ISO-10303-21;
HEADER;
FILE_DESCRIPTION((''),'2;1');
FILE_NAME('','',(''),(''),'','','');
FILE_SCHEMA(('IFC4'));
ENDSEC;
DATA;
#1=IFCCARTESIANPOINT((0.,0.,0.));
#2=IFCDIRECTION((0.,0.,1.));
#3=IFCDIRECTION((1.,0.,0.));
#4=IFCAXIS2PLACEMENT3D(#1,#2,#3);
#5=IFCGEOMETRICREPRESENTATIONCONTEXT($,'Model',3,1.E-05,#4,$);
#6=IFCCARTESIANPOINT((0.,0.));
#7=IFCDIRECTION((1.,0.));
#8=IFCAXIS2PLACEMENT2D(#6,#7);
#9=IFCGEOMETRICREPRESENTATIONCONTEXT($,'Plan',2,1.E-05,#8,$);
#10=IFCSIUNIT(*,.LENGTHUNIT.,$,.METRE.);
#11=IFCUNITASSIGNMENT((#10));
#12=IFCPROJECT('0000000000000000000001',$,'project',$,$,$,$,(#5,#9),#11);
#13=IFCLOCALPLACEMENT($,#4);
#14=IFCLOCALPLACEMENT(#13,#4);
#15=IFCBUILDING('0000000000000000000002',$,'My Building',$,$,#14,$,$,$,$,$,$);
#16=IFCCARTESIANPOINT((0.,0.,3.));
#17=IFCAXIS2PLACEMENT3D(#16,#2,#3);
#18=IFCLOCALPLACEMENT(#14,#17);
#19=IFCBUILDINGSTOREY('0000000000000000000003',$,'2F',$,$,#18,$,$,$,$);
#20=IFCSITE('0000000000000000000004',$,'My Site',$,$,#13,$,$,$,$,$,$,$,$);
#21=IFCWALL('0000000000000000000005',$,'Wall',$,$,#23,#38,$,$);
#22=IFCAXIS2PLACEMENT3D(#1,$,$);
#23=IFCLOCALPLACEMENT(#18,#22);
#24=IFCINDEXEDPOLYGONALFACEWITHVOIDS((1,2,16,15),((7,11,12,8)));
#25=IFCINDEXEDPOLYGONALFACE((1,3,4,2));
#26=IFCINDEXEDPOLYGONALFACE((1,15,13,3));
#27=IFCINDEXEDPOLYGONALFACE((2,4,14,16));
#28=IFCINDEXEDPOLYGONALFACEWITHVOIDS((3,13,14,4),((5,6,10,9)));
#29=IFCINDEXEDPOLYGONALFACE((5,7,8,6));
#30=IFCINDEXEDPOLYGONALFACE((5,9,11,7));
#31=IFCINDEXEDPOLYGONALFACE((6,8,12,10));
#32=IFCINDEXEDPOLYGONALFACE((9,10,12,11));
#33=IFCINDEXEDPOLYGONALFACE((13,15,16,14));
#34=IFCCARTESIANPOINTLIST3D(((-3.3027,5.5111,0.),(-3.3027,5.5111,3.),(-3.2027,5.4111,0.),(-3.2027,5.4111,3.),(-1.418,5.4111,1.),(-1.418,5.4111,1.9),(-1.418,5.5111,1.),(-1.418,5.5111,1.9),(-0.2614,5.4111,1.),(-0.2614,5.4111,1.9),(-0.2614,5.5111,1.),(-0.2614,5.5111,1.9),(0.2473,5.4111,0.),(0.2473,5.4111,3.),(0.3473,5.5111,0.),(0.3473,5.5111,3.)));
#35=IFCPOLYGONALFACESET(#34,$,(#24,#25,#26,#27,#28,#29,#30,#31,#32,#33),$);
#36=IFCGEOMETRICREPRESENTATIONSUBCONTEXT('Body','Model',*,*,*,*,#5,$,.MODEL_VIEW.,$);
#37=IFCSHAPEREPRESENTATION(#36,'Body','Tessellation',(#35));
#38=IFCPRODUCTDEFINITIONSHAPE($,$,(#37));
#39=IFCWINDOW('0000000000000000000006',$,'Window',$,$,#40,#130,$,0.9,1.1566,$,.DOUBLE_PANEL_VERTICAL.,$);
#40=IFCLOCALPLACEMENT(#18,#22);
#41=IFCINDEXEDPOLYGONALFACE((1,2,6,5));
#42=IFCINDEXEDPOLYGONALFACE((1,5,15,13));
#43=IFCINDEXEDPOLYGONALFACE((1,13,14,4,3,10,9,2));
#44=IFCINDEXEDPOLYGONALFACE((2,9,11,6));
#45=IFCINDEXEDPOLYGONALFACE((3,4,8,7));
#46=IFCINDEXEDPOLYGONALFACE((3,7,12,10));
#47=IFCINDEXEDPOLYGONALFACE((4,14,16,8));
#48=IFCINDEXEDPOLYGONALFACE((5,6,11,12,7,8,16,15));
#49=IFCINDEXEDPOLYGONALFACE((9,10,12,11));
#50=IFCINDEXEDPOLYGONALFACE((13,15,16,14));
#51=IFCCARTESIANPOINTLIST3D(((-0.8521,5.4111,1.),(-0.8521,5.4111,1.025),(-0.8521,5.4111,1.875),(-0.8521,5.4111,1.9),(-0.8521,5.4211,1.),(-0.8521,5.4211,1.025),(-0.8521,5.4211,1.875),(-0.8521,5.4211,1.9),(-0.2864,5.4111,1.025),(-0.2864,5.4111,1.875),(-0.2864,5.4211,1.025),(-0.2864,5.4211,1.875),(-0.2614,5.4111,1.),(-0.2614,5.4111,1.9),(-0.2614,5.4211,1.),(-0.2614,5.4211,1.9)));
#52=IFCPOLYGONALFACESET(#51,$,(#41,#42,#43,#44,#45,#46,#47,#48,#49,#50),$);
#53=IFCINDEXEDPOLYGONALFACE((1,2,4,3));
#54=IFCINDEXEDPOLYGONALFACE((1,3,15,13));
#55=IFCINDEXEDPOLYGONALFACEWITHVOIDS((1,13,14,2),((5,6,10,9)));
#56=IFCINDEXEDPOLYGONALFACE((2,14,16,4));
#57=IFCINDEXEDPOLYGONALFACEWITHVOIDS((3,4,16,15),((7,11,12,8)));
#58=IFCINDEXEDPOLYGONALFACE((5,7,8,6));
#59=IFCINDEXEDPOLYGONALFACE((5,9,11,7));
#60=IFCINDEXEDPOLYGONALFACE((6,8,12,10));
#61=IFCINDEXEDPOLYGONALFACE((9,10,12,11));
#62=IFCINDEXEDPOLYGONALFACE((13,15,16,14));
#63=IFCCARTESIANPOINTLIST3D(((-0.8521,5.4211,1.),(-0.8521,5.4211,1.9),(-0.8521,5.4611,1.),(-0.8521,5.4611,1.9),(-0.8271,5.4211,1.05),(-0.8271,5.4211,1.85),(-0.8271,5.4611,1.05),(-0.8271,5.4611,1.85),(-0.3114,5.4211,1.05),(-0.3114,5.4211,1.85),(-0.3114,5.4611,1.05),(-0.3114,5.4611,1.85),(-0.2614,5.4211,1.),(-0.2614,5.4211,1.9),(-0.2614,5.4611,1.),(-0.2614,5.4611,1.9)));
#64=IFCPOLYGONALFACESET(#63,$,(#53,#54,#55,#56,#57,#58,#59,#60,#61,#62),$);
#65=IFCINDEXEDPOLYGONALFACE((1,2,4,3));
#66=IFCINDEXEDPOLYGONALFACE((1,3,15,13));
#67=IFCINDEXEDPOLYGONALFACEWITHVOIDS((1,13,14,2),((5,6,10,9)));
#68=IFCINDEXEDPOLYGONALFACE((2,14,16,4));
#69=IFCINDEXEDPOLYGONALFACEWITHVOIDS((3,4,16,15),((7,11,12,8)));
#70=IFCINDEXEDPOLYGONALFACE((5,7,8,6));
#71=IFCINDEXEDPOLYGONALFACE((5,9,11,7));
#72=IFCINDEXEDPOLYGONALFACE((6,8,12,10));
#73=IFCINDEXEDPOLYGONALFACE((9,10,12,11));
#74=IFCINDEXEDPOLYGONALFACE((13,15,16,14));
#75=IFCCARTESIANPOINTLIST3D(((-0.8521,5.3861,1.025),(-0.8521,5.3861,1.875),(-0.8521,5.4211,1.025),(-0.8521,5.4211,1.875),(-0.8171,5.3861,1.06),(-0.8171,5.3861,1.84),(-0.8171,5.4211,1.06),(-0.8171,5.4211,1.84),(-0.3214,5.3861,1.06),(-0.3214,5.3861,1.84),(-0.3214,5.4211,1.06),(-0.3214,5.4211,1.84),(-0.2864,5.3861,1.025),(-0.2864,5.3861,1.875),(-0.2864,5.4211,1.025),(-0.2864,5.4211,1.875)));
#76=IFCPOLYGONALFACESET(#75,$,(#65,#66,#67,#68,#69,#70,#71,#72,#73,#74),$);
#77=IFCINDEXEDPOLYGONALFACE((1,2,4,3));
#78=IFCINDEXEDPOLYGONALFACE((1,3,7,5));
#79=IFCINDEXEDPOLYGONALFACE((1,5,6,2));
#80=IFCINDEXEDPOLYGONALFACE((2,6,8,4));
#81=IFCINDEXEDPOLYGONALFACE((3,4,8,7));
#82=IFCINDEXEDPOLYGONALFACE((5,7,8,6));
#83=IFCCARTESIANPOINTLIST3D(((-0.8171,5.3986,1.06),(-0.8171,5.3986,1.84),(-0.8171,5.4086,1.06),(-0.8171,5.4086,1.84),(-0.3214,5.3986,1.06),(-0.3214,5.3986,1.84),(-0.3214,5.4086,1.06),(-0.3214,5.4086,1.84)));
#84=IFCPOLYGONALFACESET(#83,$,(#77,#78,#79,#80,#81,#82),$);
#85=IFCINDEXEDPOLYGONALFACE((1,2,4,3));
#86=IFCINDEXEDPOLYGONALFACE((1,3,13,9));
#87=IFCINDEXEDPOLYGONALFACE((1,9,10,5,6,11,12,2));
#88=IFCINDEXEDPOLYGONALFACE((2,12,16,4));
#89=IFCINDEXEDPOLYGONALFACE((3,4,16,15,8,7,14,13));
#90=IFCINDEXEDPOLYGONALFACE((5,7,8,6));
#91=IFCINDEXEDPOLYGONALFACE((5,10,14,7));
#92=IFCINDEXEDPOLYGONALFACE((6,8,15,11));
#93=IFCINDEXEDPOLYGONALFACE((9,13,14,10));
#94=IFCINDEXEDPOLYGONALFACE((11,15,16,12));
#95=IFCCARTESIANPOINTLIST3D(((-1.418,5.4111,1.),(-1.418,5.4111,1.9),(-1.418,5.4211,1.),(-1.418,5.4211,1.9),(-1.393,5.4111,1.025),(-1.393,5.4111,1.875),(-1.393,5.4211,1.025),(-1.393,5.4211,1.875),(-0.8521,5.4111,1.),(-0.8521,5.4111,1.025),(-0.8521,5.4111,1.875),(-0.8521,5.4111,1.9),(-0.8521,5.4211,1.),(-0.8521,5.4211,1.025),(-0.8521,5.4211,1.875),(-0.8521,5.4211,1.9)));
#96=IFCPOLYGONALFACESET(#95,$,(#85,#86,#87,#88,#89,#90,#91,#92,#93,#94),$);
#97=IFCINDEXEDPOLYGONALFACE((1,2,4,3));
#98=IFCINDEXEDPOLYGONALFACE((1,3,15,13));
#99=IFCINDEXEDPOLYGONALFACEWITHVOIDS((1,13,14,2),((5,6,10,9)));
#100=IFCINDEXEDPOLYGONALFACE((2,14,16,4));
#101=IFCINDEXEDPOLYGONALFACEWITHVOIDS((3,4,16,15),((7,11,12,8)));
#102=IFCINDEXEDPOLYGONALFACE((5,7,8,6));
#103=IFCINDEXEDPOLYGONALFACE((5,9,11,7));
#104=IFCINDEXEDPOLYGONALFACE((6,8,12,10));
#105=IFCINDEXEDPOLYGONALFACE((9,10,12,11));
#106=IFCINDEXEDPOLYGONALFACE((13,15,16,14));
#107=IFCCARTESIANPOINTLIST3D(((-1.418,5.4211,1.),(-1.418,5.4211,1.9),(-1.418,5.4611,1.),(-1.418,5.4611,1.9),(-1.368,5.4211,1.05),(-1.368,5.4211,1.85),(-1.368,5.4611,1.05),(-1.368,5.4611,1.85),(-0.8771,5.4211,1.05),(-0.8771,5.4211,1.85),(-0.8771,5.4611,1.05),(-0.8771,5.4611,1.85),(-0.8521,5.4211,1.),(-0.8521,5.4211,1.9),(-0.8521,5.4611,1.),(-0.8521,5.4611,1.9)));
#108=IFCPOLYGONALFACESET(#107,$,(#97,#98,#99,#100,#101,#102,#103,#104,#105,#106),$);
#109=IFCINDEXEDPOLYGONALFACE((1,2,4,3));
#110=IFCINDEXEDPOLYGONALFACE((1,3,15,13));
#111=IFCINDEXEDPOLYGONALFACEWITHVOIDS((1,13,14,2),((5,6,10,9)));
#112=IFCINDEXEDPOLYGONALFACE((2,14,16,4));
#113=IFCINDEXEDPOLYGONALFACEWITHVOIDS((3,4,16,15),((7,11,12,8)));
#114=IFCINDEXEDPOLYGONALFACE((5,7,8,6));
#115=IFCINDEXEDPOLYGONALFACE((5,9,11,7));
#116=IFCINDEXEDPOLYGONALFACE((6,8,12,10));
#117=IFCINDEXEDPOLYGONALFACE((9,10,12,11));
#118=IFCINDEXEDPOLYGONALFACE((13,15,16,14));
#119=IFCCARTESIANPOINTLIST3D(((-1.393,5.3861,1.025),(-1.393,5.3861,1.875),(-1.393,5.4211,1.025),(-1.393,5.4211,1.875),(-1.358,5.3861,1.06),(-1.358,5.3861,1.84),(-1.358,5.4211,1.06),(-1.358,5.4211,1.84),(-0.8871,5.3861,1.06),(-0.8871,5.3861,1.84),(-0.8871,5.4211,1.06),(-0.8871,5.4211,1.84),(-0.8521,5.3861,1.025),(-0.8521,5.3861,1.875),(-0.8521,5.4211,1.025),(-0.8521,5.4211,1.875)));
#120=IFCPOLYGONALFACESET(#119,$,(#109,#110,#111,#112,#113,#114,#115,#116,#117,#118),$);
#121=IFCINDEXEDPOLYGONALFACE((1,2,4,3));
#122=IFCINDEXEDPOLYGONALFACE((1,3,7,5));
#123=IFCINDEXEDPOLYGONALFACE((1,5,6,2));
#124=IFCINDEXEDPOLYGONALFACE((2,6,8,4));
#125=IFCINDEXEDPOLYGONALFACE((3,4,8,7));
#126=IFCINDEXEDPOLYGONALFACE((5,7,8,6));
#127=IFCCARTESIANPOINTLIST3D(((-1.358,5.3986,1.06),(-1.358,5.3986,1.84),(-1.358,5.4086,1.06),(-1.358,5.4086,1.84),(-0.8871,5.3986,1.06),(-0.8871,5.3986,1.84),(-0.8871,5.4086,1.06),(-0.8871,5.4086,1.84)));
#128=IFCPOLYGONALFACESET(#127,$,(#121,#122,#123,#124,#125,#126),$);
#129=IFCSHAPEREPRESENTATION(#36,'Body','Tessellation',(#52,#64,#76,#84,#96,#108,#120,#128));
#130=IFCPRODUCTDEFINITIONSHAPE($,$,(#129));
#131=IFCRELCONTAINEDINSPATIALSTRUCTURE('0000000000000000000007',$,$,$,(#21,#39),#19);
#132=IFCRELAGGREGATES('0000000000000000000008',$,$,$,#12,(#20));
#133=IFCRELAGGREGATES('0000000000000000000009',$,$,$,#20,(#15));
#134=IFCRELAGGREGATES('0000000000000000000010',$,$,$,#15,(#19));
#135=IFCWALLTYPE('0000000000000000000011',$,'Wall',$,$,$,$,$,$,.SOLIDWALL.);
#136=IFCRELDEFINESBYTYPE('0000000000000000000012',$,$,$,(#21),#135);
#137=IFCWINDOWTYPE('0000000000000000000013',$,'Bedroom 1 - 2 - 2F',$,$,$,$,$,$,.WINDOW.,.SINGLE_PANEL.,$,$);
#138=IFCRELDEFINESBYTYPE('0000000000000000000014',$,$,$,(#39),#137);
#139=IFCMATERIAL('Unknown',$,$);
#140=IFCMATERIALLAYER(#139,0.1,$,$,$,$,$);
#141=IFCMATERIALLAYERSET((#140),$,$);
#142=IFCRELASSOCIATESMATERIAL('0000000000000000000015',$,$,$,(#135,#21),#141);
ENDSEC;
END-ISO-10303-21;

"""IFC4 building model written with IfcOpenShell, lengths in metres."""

from ifc_helpers import new_model, entity, si_unit, frame, origin_with_axes, origin_2d_with_axis, place, context, subcontext, project, spatial, line, indexed_curve, outline, extrude, shape, source, transform, mapped, material, layer, layer_set, layer_usage, type_object, type_shapes, element, fill, save


model = new_model("IFC4")

# Units and contexts
model_context = context("Model", 3, precision=1e-05, world=origin_with_axes())
plan_context = context("Plan", 2, precision=1e-05, world=origin_2d_with_axis())
body_context_1 = subcontext(model_context, "Body", "Model", "MODEL_VIEW")
body_context_2 = subcontext(plan_context, "Body", "Plan", "PLAN_VIEW")
ifc_project = project(units=[si_unit("LENGTHUNIT", "METRE")], contexts=[model_context, plan_context])

# Site, building, storey
site_placement = place(None, origin_with_axes())
site = spatial("IfcSite", under=ifc_project, at=site_placement, Name="My Site")
building_placement = place(site_placement, origin_with_axes())
building = spatial("IfcBuilding", under=site, at=building_placement, Name="My Building")
storey_placement = place(building_placement, frame((0.0, 0.0, 3.0), z_axis=(0.0, 0.0, 1.0), x_axis=(1.0, 0.0, 0.0)))
storey = spatial("IfcBuildingStorey", under=building, at=storey_placement, Name="2F")

# Shared definitions
ifc_material_1 = material(Name="Unknown")
ifc_layer_1 = layer(ifc_material_1, 0.1)
ifc_layer_set_1 = layer_set([ifc_layer_1])
wall_type_1 = type_object("IfcWallType", Name="Wall", PredefinedType="SOLIDWALL", material=ifc_layer_set_1)

# Wall, opening, window
ifc_layer_usage_1 = layer_usage(ifc_layer_set_1, "AXIS2", "POSITIVE", 0.0)
wall_1_placement = place(storey_placement, frame((0.3473, 5.5111, 0.0), z_axis=(0.0, 0.0, 1.0), x_axis=(-1.0, 0.0, 0.0)))
wall_1 = element("IfcWall", 1, at=wall_1_placement, inside=storey, type_object=wall_type_1, material=ifc_layer_usage_1, Name="Wall", context=body_context_1, shape_type="SweptSolid", body=[
    extrude(outline(indexed_curve([(0.0, 0.0), (0.1, 0.1), (3.55, 0.1), (3.65, 0.0)], segments=[line(1, 2, 3, 4, 1)])), origin_with_axes(), (0.0, 0.0, 1.0), 3.0),
])
shared_shape_1 = source(origin_with_axes(), body_context_1, "Body", "SweptSolid", [
    extrude(outline(indexed_curve([(0.0, 0.0), (1.1566, 0.0), (1.1566, 0.9), (0.0, 0.9)], segments=[line(1, 2, 3, 4, 1)])), frame((0.0, -0.6, 0.0), z_axis=(0.0, -1.0, 0.0), x_axis=(1.0, 0.0, 0.0)), (0.0, 0.0, -1.0), 1.2),
])
opening_1_placement = place(wall_1_placement, frame((0.6086, 0.0, 1.0), z_axis=(0.0, 0.0, 1.0), x_axis=(1.0, 0.0, 0.0)))
opening_1 = element("IfcOpeningElement", 2, at=opening_1_placement, cuts=wall_1, PredefinedType="OPENING", context=body_context_1, shape_type="MappedRepresentation", body=[
    mapped(shared_shape_1, transform((0.0, 0.0, 0.0), x_axis=(1.0, 0.0, 0.0), y_axis=(0.0, 1.0, 0.0), z_axis=(0.0, 0.0, 1.0), scale=1.0)),
])
window_type_1 = type_object("IfcWindowType", Name="Bedroom 1 - 2 - 2F", PartitioningType="SINGLE_PANEL", PredefinedType="WINDOW")
shared_shape_2 = source(origin_with_axes(), body_context_1, "Body", "SweptSolid", [
    extrude(outline(indexed_curve([(0.5908, 0.0), (0.0, 0.0), (0.0, 0.9), (0.5908, 0.9), (0.5908, 0.875), (0.025, 0.875), (0.025, 0.025), (0.5908, 0.025)], segments=[line(1, 2, 3, 4, 5, 6, 7, 8, 1)])), frame((0.0, 0.09, 0.0), z_axis=(0.0, -1.0, 0.0), x_axis=(1.0, 0.0, 0.0)), (0.0, 0.0, -1.0), 0.01),
    extrude(outline(indexed_curve([(0.0, 0.0), (0.5908, 0.0), (0.5908, 0.9), (0.0, 0.9)], segments=[line(1, 2, 3, 4, 1)]), holes=[indexed_curve([(0.05, 0.05), (0.5658, 0.05), (0.5658, 0.85), (0.05, 0.85)], segments=[line(1, 2, 3, 4, 1)])]), frame((0.0, 0.05, 0.0), z_axis=(0.0, -1.0, 0.0), x_axis=(1.0, 0.0, 0.0)), (0.0, 0.0, -1.0), 0.04),
    extrude(outline(indexed_curve([(0.0, 0.0), (0.5658, 0.0), (0.5658, 0.85), (0.0, 0.85)], segments=[line(1, 2, 3, 4, 1)]), holes=[indexed_curve([(0.035, 0.035), (0.5308, 0.035), (0.5308, 0.815), (0.035, 0.815)], segments=[line(1, 2, 3, 4, 1)])]), frame((0.025, 0.09, 0.025), z_axis=(0.0, -1.0, 0.0), x_axis=(1.0, 0.0, 0.0)), (0.0, 0.0, -1.0), 0.035),
    extrude(outline(indexed_curve([(0.035, 0.035), (0.5308, 0.035), (0.5308, 0.815), (0.035, 0.815)], segments=[line(1, 2, 3, 4, 1)])), frame((0.025, 0.1025, 0.025), z_axis=(0.0, -1.0, 0.0), x_axis=(1.0, 0.0, 0.0)), (0.0, 0.0, -1.0), 0.01),
    extrude(outline(indexed_curve([(0.0, 0.9), (0.5659, 0.9), (0.5659, 0.0), (0.0, 0.0), (0.0, 0.025), (0.5409, 0.025), (0.5409, 0.875), (0.0, 0.875)], segments=[line(1, 2, 3, 4, 5, 6, 7, 8, 1)])), frame((0.5908, 0.09, 0.0), z_axis=(0.0, -1.0, 0.0), x_axis=(1.0, 0.0, 0.0)), (0.0, 0.0, -1.0), 0.01),
    extrude(outline(indexed_curve([(0.0, 0.0), (0.5659, 0.0), (0.5659, 0.9), (0.0, 0.9)], segments=[line(1, 2, 3, 4, 1)]), holes=[indexed_curve([(0.025, 0.05), (0.5159, 0.05), (0.5159, 0.85), (0.025, 0.85)], segments=[line(1, 2, 3, 4, 1)])]), frame((0.5908, 0.05, 0.0), z_axis=(0.0, -1.0, 0.0), x_axis=(1.0, 0.0, 0.0)), (0.0, 0.0, -1.0), 0.04),
    extrude(outline(indexed_curve([(0.0, 0.0), (0.5409, 0.0), (0.5409, 0.85), (0.0, 0.85)], segments=[line(1, 2, 3, 4, 1)]), holes=[indexed_curve([(0.035, 0.035), (0.5059, 0.035), (0.5059, 0.815), (0.035, 0.815)], segments=[line(1, 2, 3, 4, 1)])]), frame((0.5908, 0.09, 0.025), z_axis=(0.0, -1.0, 0.0), x_axis=(1.0, 0.0, 0.0)), (0.0, 0.0, -1.0), 0.035),
    extrude(outline(indexed_curve([(0.035, 0.035), (0.5059, 0.035), (0.5059, 0.815), (0.035, 0.815)], segments=[line(1, 2, 3, 4, 1)])), frame((0.5908, 0.1025, 0.025), z_axis=(0.0, -1.0, 0.0), x_axis=(1.0, 0.0, 0.0)), (0.0, 0.0, -1.0), 0.01),
])
shared_shape_3 = source(origin_with_axes(), body_context_2, "Body", "Curve2D", [
    entity("IfcIndexedPolyCurve", entity("IfcCartesianPointList2D", [[0.05, 0.05], [0.5658, 0.05]])),
    entity("IfcIndexedPolyCurve", entity("IfcCartesianPointList2D", [[0.0, 0.1], [0.025, 0.1], [0.025, 0.09], [0.05, 0.09], [0.05, 0.05], [0.0, 0.05]]), [entity("IfcLineIndex", [1, 2, 3, 4, 5, 6, 1])]),
    entity("IfcIndexedPolyCurve", entity("IfcCartesianPointList2D", [[0.5908, 0.1], [0.5908, 0.1], [0.5908, 0.09], [0.5658, 0.09], [0.5658, 0.05], [0.5908, 0.05]])),
    entity("IfcIndexedPolyCurve", entity("IfcCartesianPointList2D", [[0.025, 0.09], [0.06, 0.09], [0.06, 0.125], [0.025, 0.125]]), [entity("IfcLineIndex", [1, 2, 3, 4, 1])]),
    entity("IfcIndexedPolyCurve", entity("IfcCartesianPointList2D", [[0.5908, 0.09], [0.5558, 0.09], [0.5558, 0.125], [0.5908, 0.125]]), [entity("IfcLineIndex", [1, 2, 3, 4, 1])]),
    entity("IfcIndexedPolyCurve", entity("IfcCartesianPointList2D", [[0.06, 0.09], [0.5558, 0.09]])),
    entity("IfcIndexedPolyCurve", entity("IfcCartesianPointList2D", [[0.06, 0.125], [0.5558, 0.125]])),
    entity("IfcIndexedPolyCurve", entity("IfcCartesianPointList2D", [[0.06, 0.1075], [0.5558, 0.1075]])),
    entity("IfcIndexedPolyCurve", entity("IfcCartesianPointList2D", [[0.6158, 0.05], [1.1066, 0.05]])),
    entity("IfcIndexedPolyCurve", entity("IfcCartesianPointList2D", [[0.5908, 0.1], [0.5908, 0.1], [0.5908, 0.09], [0.6158, 0.09], [0.6158, 0.05], [0.5908, 0.05]])),
    entity("IfcIndexedPolyCurve", entity("IfcCartesianPointList2D", [[1.1566, 0.1], [1.1316, 0.1], [1.1316, 0.09], [1.1066, 0.09], [1.1066, 0.05], [1.1566, 0.05]]), [entity("IfcLineIndex", [1, 2, 3, 4, 5, 6, 1])]),
    entity("IfcIndexedPolyCurve", entity("IfcCartesianPointList2D", [[0.5908, 0.09], [0.6258, 0.09], [0.6258, 0.125], [0.5908, 0.125]]), [entity("IfcLineIndex", [1, 2, 3, 4, 1])]),
    entity("IfcIndexedPolyCurve", entity("IfcCartesianPointList2D", [[1.1316, 0.09], [1.0966, 0.09], [1.0966, 0.125], [1.1316, 0.125]]), [entity("IfcLineIndex", [1, 2, 3, 4, 1])]),
    entity("IfcIndexedPolyCurve", entity("IfcCartesianPointList2D", [[0.6258, 0.09], [1.0966, 0.09]])),
    entity("IfcIndexedPolyCurve", entity("IfcCartesianPointList2D", [[0.6258, 0.125], [1.0966, 0.125]])),
    entity("IfcIndexedPolyCurve", entity("IfcCartesianPointList2D", [[0.6258, 0.1075], [1.0966, 0.1075]])),
])
type_shapes(window_type_1, [shared_shape_2, shared_shape_3])
window_1_placement = place(opening_1_placement, frame((0.0, 0.0, 0.0), z_axis=(0.0, 0.0, 1.0), x_axis=(1.0, 0.0, 0.0)))
window_1 = element("IfcWindow", 3, at=window_1_placement, inside=storey, type_object=window_type_1, Name="Window", OverallHeight=0.9, OverallWidth=1.1566, PartitioningType="DOUBLE_PANEL_VERTICAL", shapes=[
    shape(body_context_1, "Body", "MappedRepresentation", [mapped(shared_shape_2, transform((0.0, 0.0, 0.0), x_axis=(1.0, 0.0, 0.0), y_axis=(0.0, 1.0, 0.0), z_axis=(0.0, 0.0, 1.0), scale=1.0))]),
    shape(body_context_2, "Body", "MappedRepresentation", [mapped(shared_shape_3, transform((0.0, 0.0, 0.0), x_axis=(1.0, 0.0, 0.0), y_axis=(0.0, 1.0, 0.0), z_axis=(0.0, 0.0, 1.0), scale=1.0))]),
])
fill(opening_1, window_1)

save(model, "model.ifc")
